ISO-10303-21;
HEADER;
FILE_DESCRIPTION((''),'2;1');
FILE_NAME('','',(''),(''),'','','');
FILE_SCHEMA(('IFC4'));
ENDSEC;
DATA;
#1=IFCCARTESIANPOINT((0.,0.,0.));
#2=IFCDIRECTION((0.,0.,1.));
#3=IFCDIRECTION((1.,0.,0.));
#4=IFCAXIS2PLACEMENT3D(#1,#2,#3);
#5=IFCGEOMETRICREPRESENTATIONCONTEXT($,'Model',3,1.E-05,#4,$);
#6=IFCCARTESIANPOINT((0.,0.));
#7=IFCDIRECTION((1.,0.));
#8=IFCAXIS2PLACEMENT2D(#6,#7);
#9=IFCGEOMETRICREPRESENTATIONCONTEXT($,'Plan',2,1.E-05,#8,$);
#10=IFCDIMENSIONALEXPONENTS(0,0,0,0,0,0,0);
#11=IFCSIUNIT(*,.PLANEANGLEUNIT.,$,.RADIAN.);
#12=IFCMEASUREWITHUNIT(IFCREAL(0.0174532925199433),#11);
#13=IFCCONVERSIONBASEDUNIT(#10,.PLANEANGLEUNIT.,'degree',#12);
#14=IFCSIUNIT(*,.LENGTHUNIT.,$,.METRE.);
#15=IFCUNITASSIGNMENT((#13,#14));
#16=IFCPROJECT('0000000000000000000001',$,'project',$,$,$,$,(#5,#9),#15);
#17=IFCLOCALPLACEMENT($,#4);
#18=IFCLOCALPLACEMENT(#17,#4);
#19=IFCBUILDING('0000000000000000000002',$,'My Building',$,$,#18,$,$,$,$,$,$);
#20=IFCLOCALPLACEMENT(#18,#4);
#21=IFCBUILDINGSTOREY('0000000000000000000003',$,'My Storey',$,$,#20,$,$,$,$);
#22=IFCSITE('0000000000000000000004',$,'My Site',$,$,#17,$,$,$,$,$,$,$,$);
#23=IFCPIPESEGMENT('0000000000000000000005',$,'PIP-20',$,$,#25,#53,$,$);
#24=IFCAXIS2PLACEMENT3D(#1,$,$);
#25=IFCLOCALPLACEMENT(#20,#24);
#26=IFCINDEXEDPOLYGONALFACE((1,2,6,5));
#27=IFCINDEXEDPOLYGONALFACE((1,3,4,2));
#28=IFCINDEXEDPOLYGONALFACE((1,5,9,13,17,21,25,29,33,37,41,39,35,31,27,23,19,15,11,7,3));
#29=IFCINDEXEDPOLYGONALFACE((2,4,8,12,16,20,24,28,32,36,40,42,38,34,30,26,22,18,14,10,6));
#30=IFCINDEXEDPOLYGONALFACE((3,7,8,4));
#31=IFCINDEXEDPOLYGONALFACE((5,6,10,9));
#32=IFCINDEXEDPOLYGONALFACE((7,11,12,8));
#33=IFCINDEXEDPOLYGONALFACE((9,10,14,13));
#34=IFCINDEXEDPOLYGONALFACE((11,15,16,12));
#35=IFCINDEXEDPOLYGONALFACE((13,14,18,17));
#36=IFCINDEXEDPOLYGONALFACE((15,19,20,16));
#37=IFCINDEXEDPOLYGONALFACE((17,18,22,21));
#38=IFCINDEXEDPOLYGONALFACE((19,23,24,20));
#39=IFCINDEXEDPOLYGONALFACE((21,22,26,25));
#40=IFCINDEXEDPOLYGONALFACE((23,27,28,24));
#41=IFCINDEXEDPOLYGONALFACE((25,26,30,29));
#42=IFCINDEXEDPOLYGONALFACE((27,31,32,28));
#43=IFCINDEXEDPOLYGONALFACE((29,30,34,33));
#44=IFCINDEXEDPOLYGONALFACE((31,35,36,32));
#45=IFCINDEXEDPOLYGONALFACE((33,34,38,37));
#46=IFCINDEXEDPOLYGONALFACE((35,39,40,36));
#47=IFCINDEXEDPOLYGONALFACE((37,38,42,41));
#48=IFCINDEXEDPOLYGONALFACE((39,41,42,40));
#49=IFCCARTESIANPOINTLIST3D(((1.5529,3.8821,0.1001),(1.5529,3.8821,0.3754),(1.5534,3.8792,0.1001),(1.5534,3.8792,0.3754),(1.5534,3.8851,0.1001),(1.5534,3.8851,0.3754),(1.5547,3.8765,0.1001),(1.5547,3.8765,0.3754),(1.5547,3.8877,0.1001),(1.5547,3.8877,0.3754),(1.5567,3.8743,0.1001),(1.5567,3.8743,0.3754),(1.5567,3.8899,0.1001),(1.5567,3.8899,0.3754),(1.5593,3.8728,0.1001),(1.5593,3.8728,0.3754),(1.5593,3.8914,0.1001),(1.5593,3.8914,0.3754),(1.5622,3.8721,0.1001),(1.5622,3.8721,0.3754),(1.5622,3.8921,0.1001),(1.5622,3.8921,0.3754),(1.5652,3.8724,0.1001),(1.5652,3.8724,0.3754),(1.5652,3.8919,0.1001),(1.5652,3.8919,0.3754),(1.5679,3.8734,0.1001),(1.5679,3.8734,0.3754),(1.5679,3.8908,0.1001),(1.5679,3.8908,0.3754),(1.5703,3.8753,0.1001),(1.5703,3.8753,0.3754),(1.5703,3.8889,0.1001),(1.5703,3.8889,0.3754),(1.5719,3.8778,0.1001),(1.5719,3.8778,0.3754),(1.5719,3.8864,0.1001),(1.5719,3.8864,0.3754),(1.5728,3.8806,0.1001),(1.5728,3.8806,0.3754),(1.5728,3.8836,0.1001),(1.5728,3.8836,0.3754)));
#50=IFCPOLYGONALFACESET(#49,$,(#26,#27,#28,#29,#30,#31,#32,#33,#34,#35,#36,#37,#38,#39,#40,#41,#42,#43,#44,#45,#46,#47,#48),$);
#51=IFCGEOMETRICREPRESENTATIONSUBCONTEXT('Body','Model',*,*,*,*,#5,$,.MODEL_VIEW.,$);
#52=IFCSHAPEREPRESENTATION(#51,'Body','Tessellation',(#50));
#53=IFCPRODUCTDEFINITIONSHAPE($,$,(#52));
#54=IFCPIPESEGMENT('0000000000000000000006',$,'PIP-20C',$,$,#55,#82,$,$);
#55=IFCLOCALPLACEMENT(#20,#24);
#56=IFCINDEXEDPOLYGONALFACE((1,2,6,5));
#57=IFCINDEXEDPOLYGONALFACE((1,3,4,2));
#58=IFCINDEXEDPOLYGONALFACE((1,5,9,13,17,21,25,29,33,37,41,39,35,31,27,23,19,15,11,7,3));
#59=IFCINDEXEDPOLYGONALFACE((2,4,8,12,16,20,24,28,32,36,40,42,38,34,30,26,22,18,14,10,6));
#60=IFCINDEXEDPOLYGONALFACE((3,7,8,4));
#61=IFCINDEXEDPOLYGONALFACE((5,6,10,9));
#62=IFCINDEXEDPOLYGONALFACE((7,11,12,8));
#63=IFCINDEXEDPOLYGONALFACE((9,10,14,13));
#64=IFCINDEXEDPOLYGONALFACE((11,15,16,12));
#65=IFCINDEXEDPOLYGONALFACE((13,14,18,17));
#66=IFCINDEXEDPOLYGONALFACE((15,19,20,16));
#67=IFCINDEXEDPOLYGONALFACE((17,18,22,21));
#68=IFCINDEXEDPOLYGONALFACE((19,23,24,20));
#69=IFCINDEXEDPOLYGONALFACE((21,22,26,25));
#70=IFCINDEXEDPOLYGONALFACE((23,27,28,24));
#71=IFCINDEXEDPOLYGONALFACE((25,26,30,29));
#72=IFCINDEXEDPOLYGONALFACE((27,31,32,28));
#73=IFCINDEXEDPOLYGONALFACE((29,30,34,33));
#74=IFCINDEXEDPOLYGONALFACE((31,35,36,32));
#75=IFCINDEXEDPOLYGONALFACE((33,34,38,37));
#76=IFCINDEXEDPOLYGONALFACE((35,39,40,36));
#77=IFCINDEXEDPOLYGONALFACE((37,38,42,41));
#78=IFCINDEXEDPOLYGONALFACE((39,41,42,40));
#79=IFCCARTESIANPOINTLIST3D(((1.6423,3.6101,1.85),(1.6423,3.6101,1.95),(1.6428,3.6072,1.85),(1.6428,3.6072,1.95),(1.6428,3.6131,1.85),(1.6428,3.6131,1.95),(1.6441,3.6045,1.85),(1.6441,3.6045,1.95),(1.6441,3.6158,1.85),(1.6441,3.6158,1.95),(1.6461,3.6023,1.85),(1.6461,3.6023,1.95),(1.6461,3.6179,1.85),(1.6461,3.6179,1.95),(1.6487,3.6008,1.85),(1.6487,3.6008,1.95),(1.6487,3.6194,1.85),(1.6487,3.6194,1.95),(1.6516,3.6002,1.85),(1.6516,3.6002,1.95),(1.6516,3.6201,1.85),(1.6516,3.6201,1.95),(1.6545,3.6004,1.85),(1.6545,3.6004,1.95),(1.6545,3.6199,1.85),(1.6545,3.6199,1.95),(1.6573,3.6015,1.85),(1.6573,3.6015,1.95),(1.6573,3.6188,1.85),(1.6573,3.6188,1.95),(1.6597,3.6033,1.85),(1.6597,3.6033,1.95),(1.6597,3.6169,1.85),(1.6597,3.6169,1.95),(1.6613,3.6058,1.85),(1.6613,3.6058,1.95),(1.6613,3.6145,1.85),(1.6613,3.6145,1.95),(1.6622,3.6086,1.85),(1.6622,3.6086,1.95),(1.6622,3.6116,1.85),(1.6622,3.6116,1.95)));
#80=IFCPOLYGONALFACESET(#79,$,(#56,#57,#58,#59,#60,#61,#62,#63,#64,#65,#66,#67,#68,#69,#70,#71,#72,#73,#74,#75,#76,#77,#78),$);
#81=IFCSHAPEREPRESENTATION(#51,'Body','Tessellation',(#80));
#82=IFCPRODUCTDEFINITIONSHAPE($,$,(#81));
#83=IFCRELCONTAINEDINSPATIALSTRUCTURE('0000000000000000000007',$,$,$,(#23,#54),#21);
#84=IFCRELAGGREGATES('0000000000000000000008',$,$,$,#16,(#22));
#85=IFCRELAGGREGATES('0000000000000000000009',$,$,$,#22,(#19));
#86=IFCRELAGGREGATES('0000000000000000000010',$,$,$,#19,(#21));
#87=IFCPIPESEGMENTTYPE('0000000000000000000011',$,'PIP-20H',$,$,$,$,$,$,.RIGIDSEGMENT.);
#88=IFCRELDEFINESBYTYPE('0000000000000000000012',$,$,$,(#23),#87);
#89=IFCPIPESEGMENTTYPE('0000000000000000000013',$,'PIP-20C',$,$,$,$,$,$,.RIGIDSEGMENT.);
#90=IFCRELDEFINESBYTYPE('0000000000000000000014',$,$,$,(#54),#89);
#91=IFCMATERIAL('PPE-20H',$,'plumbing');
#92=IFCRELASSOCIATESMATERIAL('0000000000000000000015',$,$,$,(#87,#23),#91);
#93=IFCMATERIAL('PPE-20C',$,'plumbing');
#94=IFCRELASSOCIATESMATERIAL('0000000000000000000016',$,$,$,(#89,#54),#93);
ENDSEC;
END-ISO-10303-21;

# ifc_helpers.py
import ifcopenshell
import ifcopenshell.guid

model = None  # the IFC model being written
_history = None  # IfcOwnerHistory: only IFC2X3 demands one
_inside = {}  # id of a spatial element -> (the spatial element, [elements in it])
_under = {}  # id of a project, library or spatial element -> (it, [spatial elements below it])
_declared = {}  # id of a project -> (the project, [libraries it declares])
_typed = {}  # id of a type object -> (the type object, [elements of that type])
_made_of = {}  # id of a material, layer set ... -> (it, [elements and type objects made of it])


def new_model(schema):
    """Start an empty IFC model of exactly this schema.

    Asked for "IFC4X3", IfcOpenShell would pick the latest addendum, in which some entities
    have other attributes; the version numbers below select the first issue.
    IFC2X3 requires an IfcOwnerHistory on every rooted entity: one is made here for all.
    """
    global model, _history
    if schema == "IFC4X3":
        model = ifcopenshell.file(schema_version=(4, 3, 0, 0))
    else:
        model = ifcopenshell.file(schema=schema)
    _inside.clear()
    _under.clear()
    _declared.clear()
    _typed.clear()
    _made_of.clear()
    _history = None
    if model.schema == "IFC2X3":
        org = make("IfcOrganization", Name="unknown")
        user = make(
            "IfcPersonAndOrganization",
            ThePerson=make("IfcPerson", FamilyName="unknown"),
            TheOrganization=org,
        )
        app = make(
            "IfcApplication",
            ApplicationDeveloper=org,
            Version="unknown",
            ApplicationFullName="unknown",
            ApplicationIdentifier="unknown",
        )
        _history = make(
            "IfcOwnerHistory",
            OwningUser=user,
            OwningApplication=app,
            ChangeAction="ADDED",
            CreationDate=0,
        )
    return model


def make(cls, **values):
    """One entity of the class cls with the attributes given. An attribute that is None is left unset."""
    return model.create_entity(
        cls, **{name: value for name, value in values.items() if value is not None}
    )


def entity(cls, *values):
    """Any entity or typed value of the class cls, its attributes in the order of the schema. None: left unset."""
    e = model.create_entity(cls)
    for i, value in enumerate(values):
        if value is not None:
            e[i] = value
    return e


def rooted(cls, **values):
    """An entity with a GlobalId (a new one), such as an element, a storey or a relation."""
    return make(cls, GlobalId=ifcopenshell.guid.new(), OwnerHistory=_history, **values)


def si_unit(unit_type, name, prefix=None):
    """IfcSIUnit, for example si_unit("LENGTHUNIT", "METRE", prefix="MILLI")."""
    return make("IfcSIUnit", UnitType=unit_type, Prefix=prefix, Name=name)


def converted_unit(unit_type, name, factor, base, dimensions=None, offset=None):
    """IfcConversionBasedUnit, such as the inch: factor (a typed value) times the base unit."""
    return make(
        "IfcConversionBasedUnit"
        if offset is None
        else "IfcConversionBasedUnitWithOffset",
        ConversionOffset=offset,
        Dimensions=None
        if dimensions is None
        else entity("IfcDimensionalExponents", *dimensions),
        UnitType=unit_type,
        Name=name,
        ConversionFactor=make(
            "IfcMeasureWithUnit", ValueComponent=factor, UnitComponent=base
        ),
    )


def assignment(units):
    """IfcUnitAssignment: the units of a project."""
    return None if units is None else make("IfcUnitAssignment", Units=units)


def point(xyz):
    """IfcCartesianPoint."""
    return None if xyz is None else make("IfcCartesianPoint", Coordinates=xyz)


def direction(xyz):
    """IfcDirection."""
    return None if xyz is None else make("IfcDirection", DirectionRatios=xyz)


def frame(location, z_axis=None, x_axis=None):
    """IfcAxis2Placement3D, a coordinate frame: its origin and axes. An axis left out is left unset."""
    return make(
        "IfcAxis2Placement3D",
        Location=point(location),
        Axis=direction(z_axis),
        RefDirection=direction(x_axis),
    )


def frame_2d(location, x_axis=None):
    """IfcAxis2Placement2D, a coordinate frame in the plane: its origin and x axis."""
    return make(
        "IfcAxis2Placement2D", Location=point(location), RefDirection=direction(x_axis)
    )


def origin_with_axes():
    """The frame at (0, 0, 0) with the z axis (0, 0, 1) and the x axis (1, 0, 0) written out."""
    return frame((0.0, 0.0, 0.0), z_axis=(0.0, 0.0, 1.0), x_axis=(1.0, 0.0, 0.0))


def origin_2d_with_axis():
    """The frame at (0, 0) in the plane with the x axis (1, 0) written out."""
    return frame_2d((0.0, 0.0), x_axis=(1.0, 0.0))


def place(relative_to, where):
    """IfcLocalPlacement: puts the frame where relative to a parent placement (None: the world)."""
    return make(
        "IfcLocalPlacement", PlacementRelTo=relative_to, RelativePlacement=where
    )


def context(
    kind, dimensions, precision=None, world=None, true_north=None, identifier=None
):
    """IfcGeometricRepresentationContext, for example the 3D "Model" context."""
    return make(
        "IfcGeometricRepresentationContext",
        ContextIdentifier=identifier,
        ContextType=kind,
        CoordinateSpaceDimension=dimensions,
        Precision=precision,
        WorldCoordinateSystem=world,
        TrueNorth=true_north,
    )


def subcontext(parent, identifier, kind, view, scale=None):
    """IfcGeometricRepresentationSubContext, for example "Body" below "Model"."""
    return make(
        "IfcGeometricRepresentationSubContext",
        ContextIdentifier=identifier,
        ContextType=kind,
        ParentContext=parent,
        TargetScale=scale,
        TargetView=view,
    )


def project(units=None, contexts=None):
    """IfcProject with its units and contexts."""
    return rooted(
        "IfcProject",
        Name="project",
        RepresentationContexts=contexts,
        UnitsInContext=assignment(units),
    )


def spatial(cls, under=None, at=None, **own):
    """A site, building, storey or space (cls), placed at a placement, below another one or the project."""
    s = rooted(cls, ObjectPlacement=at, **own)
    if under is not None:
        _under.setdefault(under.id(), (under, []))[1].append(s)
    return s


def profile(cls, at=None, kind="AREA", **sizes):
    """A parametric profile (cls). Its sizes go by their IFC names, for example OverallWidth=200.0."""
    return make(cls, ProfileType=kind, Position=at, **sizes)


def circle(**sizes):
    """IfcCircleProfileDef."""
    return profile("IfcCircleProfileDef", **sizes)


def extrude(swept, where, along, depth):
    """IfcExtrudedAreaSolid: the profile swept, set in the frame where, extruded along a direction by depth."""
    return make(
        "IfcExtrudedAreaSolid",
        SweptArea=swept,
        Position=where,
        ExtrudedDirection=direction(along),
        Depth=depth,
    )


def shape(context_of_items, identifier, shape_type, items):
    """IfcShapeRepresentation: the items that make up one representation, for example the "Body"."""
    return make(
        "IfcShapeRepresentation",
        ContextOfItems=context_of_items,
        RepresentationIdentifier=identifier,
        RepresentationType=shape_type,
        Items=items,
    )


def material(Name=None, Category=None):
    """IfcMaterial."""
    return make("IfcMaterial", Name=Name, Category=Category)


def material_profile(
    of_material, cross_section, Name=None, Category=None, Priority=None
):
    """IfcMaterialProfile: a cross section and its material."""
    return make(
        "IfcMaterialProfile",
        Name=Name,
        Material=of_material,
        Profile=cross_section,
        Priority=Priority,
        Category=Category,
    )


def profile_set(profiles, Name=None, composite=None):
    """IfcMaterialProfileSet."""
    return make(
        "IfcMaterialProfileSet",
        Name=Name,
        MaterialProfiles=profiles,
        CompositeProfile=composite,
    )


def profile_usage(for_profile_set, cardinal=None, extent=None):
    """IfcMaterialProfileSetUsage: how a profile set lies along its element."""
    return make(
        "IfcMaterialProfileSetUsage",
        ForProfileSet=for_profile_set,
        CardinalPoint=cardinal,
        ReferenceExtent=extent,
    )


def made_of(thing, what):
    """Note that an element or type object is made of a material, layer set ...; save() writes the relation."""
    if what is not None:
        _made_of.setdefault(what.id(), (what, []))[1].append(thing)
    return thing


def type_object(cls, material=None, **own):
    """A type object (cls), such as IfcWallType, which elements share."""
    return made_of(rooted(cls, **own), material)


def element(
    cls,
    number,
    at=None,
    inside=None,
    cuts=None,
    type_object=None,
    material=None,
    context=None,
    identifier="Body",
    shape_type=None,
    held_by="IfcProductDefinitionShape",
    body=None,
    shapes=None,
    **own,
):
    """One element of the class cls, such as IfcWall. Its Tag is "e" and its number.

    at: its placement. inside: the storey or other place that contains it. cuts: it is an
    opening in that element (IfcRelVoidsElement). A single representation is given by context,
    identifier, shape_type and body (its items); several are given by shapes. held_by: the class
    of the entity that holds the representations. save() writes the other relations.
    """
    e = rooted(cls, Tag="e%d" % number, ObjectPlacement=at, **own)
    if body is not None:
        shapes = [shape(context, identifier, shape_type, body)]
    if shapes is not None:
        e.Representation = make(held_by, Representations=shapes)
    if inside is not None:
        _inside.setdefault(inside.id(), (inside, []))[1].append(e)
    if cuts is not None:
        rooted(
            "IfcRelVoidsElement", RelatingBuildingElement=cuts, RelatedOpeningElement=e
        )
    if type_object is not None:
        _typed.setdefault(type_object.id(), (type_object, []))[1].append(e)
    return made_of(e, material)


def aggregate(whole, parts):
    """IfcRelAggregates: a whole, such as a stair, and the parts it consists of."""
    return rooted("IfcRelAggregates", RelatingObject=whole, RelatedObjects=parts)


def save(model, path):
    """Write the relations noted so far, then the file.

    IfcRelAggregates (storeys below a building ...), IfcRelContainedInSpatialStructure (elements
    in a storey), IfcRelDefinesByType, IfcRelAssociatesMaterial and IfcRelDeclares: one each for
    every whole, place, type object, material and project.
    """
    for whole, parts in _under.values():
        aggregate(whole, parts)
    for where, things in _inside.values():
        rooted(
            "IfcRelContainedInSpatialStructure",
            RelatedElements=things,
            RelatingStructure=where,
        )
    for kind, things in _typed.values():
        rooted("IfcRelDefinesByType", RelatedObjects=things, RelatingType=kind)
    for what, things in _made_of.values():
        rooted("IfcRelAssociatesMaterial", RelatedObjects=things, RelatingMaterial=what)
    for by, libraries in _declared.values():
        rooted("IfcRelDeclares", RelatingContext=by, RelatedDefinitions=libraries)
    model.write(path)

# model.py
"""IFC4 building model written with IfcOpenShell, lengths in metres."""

from ifc_helpers import new_model, entity, si_unit, converted_unit, frame, origin_with_axes, origin_2d_with_axis, place, context, subcontext, project, spatial, circle, extrude, material, material_profile, profile_set, profile_usage, type_object, element, save


model = new_model("IFC4")

# Units and contexts
model_context = context("Model", 3, precision=1e-05, world=origin_with_axes())
plan_context = context("Plan", 2, precision=1e-05, world=origin_2d_with_axis())
body_context = subcontext(model_context, "Body", "Model", "MODEL_VIEW")
ifc_project = project(units=[converted_unit("PLANEANGLEUNIT", "degree", entity("IfcReal", 0.0174532925199433), si_unit("PLANEANGLEUNIT", "RADIAN"), dimensions=[0, 0, 0, 0, 0, 0, 0]), si_unit("LENGTHUNIT", "METRE")], contexts=[model_context, plan_context])

# Site, building, storey
site_placement = place(None, origin_with_axes())
site = spatial("IfcSite", under=ifc_project, at=site_placement, Name="My Site")
building_placement = place(site_placement, origin_with_axes())
building = spatial("IfcBuilding", under=site, at=building_placement, Name="My Building")
storey_placement = place(building_placement, origin_with_axes())
storey = spatial("IfcBuildingStorey", under=building, at=storey_placement, Name="My Storey")

# Pipe segment
ifc_material_1 = material(Name="PPE-20H", Category="plumbing")
ifc_material_profile_1 = material_profile(ifc_material_1, circle(Radius=0.01, kind="CURVE"))
ifc_profile_set_1 = profile_set([ifc_material_profile_1])
pipe_segment_type_1 = type_object("IfcPipeSegmentType", Name="PIP-20H", PredefinedType="RIGIDSEGMENT", material=ifc_profile_set_1)
ifc_profile_usage_1 = profile_usage(ifc_profile_set_1, cardinal=5)
pipe_segment_1_placement = place(storey_placement, frame((1.5629, 3.8821, 0.3754), z_axis=(0.0, 0.0, -1.0), x_axis=(-1.0, 0.0, 0.0)))
element("IfcPipeSegment", 1, at=pipe_segment_1_placement, inside=storey, type_object=pipe_segment_type_1, material=ifc_profile_usage_1, Name="PIP-20", context=body_context, shape_type="SweptSolid", body=[
    extrude(circle(Radius=0.01, kind="CURVE"), origin_with_axes(), (0.0, 0.0, 1.0), 0.2753),
])

# Pipe segment
ifc_material_2 = material(Name="PPE-20C", Category="plumbing")
ifc_material_profile_2 = material_profile(ifc_material_2, circle(Radius=0.01, kind="CURVE"))
ifc_profile_set_2 = profile_set([ifc_material_profile_2])
ifc_profile_usage_2 = profile_usage(ifc_profile_set_2)
pipe_segment_type_2 = type_object("IfcPipeSegmentType", Name="PIP-20C", PredefinedType="RIGIDSEGMENT", material=ifc_profile_set_2)
pipe_segment_2_placement = place(storey_placement, frame((1.6523, 3.6101, 1.95), z_axis=(0.0, 0.0, -1.0), x_axis=(-1.0, 0.0, 0.0)))
element("IfcPipeSegment", 2, at=pipe_segment_2_placement, inside=storey, type_object=pipe_segment_type_2, material=ifc_profile_usage_2, Name="PIP-20C", context=body_context, shape_type="SweptSolid", body=[
    extrude(circle(Radius=0.01, kind="CURVE"), origin_with_axes(), (0.0, 0.0, 1.0), 0.1),
])

save(model, "model.ifc")
